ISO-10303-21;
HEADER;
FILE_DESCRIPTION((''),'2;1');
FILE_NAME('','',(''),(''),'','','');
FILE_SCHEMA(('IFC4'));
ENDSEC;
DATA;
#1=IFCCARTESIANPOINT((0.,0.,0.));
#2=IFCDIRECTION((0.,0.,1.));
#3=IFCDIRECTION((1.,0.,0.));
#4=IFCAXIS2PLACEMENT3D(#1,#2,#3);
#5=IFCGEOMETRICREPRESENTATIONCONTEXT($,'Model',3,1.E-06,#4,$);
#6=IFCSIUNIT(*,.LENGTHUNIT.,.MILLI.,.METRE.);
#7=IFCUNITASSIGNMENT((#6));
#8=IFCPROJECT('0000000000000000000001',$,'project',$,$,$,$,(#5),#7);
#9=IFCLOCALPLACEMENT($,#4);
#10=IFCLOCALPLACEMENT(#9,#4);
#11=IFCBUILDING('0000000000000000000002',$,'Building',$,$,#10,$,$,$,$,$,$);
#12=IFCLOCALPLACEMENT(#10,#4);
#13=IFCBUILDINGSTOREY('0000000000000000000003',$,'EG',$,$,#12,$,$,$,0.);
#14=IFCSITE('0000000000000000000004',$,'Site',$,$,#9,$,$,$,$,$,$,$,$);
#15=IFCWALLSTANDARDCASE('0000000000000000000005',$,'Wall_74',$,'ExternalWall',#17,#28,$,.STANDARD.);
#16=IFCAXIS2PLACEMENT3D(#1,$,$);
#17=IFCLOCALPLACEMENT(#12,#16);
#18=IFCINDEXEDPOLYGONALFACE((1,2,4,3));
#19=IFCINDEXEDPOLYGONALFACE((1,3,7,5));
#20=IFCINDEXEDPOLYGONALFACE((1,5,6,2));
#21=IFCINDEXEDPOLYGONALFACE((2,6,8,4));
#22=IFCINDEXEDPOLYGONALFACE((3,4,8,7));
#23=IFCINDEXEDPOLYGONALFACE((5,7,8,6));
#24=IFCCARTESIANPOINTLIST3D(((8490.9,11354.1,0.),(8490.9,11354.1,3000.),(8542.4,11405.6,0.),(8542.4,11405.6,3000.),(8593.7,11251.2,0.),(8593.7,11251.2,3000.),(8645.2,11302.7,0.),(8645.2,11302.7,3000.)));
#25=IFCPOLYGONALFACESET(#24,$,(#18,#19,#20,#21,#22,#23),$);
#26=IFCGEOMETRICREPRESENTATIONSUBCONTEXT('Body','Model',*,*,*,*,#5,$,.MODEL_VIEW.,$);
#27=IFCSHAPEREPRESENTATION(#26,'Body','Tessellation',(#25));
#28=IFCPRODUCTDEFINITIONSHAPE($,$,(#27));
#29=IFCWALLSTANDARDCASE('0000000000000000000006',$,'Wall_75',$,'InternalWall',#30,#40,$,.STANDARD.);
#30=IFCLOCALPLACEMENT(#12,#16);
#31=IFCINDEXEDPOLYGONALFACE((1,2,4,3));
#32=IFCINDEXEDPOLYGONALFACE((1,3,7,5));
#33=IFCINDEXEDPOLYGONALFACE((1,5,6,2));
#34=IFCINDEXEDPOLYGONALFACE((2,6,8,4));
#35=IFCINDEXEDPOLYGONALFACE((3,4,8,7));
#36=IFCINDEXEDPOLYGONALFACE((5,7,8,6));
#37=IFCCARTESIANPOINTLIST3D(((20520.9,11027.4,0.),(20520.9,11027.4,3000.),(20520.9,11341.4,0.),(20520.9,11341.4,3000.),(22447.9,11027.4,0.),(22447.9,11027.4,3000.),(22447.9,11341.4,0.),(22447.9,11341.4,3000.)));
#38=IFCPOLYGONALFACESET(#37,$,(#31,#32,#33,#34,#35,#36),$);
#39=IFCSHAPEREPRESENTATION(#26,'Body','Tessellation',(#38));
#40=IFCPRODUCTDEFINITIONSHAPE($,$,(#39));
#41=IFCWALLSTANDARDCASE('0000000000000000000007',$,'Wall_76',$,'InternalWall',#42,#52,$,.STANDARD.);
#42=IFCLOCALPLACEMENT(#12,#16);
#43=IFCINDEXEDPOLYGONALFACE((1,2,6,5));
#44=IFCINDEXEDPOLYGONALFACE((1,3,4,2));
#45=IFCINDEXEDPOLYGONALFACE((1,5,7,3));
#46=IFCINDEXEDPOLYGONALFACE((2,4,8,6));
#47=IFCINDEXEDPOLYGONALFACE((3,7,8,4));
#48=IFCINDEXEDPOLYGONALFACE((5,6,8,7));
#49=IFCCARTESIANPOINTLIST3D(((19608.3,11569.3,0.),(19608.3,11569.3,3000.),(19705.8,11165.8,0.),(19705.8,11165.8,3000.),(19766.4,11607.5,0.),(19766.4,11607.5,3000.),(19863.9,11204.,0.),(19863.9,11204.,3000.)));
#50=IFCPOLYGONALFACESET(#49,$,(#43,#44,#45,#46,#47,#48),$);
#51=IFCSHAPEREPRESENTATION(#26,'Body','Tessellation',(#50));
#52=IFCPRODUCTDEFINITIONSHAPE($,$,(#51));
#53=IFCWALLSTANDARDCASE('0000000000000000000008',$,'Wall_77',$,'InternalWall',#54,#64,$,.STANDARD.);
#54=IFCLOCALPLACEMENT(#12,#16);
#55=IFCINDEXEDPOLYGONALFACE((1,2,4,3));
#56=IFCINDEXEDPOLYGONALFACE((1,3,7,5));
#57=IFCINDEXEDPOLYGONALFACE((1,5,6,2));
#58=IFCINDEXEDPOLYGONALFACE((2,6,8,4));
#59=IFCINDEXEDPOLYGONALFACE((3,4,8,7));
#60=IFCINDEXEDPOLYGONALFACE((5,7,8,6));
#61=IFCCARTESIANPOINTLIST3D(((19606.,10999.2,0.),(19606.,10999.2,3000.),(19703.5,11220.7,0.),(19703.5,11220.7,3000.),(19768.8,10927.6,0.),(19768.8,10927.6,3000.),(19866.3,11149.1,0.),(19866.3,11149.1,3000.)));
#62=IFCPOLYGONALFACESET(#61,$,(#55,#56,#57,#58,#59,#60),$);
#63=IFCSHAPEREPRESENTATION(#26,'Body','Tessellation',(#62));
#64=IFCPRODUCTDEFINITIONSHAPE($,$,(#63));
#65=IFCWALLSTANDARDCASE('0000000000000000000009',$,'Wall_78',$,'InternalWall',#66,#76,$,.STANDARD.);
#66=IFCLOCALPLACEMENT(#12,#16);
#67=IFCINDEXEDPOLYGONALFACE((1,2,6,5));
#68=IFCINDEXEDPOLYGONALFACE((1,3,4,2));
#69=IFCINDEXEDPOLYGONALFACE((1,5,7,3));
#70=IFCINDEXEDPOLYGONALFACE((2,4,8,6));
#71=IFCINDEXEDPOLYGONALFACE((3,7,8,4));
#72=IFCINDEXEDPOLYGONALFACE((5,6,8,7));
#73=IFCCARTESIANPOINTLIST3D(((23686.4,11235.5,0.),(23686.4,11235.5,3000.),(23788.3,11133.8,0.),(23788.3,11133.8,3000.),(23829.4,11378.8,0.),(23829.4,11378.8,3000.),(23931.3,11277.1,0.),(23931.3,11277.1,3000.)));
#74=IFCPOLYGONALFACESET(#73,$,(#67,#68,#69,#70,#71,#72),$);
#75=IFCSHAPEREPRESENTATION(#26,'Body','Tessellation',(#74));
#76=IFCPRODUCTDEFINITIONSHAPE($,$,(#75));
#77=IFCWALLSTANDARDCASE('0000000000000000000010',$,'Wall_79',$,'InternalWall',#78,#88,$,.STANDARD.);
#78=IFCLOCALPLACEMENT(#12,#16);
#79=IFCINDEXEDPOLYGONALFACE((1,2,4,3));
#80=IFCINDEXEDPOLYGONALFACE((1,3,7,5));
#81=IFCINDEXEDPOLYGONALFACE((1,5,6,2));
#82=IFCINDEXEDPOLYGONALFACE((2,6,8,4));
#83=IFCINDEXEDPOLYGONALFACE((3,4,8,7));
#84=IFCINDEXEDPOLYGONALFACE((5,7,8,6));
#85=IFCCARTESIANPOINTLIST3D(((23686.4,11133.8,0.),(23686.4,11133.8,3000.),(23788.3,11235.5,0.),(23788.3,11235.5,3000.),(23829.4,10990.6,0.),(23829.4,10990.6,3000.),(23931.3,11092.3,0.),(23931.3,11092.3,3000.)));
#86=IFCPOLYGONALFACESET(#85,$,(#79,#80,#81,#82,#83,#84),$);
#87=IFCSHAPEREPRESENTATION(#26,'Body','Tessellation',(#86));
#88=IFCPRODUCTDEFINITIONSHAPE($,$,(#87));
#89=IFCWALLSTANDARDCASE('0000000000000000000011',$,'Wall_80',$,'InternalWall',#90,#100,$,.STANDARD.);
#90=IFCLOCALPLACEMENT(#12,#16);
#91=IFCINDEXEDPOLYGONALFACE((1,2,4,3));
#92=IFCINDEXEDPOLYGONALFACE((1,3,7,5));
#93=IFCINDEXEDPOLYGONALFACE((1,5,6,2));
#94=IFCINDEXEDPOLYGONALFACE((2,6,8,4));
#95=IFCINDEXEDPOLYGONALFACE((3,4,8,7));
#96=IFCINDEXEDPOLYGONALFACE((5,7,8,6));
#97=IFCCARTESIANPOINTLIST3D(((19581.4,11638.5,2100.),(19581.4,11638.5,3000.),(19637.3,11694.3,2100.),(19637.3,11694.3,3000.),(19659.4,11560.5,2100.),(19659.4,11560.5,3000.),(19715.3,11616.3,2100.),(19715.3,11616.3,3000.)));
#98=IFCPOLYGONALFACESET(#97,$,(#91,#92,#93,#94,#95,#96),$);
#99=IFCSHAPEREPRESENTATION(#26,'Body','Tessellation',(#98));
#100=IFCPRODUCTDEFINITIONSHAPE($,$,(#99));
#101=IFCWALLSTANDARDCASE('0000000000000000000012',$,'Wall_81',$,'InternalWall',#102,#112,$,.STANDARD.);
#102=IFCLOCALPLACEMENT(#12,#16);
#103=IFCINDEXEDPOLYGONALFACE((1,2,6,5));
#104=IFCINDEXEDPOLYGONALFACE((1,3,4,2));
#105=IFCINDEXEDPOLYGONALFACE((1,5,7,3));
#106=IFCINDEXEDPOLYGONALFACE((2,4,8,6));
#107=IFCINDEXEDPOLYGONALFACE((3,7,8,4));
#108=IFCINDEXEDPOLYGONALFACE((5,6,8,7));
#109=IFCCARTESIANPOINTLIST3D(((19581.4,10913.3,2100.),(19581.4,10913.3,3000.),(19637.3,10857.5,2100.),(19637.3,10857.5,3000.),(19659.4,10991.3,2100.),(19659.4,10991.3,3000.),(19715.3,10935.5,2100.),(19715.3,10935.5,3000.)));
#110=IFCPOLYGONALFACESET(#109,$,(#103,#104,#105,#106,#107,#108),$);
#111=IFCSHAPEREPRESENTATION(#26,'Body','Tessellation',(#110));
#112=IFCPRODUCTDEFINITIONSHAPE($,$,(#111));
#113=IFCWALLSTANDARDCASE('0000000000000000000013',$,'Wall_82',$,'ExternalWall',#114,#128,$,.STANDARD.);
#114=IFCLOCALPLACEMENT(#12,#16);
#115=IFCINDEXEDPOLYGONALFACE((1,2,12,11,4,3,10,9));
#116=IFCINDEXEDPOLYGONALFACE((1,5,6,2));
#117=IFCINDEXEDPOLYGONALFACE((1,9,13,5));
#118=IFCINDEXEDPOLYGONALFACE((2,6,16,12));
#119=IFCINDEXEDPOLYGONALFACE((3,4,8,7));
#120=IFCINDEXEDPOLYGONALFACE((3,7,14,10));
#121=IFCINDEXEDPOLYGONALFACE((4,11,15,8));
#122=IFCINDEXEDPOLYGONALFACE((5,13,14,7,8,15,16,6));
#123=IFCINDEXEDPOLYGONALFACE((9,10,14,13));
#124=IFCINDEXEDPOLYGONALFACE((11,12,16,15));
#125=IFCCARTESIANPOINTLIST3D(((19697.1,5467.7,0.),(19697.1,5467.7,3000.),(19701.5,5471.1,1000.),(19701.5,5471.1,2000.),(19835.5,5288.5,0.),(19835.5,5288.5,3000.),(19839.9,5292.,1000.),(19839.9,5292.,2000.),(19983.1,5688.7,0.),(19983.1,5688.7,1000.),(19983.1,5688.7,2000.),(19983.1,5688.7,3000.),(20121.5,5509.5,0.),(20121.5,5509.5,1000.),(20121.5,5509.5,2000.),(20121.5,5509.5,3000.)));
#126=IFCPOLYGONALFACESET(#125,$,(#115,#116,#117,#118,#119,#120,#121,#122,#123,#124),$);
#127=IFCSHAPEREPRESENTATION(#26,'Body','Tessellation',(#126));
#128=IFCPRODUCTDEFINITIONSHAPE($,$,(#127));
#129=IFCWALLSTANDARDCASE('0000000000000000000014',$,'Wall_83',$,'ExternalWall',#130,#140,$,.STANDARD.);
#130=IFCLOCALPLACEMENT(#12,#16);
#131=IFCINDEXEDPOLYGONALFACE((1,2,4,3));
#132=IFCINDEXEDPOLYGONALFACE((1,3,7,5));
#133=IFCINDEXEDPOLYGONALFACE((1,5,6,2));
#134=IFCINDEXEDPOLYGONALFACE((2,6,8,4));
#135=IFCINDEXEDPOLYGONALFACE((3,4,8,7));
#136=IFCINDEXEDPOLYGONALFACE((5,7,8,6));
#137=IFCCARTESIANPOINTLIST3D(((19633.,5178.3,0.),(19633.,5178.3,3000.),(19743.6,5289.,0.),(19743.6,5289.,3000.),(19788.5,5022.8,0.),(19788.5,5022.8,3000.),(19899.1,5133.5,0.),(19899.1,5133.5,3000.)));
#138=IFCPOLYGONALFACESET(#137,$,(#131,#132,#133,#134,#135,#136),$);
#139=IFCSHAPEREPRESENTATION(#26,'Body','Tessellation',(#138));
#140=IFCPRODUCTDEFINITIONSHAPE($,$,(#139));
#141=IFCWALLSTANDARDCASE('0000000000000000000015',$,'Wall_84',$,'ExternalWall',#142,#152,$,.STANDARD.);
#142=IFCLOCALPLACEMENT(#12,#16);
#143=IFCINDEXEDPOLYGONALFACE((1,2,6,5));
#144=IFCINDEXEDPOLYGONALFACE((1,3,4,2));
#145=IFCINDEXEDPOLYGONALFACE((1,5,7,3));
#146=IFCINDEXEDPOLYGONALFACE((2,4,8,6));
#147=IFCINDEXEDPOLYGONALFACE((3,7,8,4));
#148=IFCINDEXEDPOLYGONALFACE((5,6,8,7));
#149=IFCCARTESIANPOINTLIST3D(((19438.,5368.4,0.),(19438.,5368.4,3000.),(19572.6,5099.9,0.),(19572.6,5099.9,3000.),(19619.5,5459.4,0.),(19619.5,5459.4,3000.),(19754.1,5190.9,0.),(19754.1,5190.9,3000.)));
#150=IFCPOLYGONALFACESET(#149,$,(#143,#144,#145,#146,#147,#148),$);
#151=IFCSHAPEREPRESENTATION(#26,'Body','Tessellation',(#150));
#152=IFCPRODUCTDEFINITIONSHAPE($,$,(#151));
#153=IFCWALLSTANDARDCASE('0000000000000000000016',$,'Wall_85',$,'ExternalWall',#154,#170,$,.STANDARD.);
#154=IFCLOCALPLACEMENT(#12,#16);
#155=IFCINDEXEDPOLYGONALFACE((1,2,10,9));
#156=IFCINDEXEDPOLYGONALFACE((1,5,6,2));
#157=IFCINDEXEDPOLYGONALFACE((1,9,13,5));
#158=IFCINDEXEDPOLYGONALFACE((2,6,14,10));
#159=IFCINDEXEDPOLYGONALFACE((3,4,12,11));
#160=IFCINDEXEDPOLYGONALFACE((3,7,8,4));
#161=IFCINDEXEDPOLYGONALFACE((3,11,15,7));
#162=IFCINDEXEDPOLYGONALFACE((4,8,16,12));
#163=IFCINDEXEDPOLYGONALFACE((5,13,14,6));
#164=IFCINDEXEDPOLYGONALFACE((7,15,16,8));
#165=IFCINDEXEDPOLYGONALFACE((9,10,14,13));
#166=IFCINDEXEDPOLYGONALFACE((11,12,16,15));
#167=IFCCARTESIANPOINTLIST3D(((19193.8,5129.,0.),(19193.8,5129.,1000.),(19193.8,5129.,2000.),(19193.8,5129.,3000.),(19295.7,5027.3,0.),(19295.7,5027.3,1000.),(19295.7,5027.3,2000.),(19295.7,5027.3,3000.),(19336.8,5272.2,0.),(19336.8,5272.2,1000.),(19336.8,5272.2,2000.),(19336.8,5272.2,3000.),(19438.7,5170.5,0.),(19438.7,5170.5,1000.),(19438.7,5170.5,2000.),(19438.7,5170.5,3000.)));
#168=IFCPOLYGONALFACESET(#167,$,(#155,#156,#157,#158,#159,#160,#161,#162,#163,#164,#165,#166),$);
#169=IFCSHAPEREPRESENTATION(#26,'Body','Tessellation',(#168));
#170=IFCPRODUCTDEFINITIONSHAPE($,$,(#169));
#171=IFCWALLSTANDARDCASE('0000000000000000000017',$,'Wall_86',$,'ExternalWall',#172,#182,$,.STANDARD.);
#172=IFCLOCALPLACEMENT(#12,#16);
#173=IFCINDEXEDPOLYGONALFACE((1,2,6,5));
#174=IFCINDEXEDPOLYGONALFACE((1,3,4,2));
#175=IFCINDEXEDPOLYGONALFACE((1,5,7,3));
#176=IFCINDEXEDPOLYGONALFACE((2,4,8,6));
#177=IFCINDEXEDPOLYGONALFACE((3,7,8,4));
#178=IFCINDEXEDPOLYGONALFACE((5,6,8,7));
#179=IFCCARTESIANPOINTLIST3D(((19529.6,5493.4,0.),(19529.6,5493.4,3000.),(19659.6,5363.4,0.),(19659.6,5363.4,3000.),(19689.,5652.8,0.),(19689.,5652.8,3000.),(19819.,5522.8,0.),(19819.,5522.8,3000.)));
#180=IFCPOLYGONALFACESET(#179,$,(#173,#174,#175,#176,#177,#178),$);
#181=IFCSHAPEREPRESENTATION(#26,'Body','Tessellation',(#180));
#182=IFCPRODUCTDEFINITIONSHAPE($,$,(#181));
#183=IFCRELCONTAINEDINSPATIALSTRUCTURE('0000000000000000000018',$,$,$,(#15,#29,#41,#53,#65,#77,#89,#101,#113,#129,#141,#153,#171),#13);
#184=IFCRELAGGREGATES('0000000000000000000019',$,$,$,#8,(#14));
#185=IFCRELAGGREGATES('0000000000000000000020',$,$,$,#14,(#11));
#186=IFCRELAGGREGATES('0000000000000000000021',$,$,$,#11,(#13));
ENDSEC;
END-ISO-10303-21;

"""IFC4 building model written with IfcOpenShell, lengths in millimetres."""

from ifc_helpers import new_model, si_unit, frame, origin_with_axes, place, context, subcontext, project, spatial, rectangle, extrude, element, save


model = new_model("IFC4")

# Units and contexts
model_context = context("Model", 3, precision=1e-06, world=origin_with_axes())
body_context = subcontext(model_context, "Body", "Model", "MODEL_VIEW")
ifc_project = project(units=[si_unit("LENGTHUNIT", "METRE", prefix="MILLI")], contexts=[model_context])

# Site, building, storey
site_placement = place(None, origin_with_axes())
site = spatial("IfcSite", under=ifc_project, at=site_placement, Name="Site")
building_placement = place(site_placement, origin_with_axes())
building = spatial("IfcBuilding", under=site, at=building_placement, Name="Building")
storey_placement = place(building_placement, origin_with_axes())
storey = spatial("IfcBuildingStorey", under=building, at=storey_placement, Name="EG", Elevation=0.0)

# Walls
wall_1_placement = place(storey_placement, origin_with_axes())
element("IfcWallStandardCase", 1, at=wall_1_placement, inside=storey, Name="Wall_74", ObjectType="ExternalWall", PredefinedType="STANDARD", context=body_context, shape_type="SweptSolid", body=[
    extrude(rectangle(XDim=72.8, YDim=145.5), frame((8568.0, 11328.4, 0.0), z_axis=(0.0, 0.0, 1.0), x_axis=(-0.707107, -0.707107, 0.0)), (0.0, 0.0, 1.0), 3000.0),
])
wall_2_placement = place(storey_placement, origin_with_axes())
element("IfcWallStandardCase", 2, at=wall_2_placement, inside=storey, Name="Wall_75", ObjectType="InternalWall", PredefinedType="STANDARD", context=body_context, shape_type="SweptSolid", body=[
    extrude(rectangle(XDim=1927.0, YDim=314.0), frame((21484.4, 11184.4, 0.0), z_axis=(0.0, 0.0, 1.0), x_axis=(1.0, 0.0, 0.0)), (0.0, 0.0, 1.0), 3000.0),
])
wall_3_placement = place(storey_placement, origin_with_axes())
element("IfcWallStandardCase", 3, at=wall_3_placement, inside=storey, Name="Wall_76", ObjectType="InternalWall", PredefinedType="STANDARD", context=body_context, shape_type="SweptSolid", body=[
    extrude(rectangle(XDim=415.1, YDim=162.7), frame((19736.1, 11386.7, 0.0), z_axis=(0.0, 0.0, 1.0), x_axis=(0.234876, -0.972025, 0.0)), (0.0, 0.0, 1.0), 3000.0),
])
wall_4_placement = place(storey_placement, origin_with_axes())
element("IfcWallStandardCase", 4, at=wall_4_placement, inside=storey, Name="Wall_77", ObjectType="InternalWall", PredefinedType="STANDARD", context=body_context, shape_type="SweptSolid", body=[
    extrude(rectangle(XDim=242.0, YDim=177.9), frame((19736.1, 11074.2, 0.0), z_axis=(0.0, 0.0, 1.0), x_axis=(-0.402877, -0.915254, 0.0)), (0.0, 0.0, 1.0), 3000.0),
])
wall_5_placement = place(storey_placement, origin_with_axes())
element("IfcWallStandardCase", 5, at=wall_5_placement, inside=storey, Name="Wall_78", ObjectType="InternalWall", PredefinedType="STANDARD", context=body_context, shape_type="SweptSolid", body=[
    extrude(rectangle(XDim=202.4, YDim=144.0), frame((23808.9, 11256.3, 0.0), z_axis=(0.0, 0.0, 1.0), x_axis=(0.706489, 0.707724, 0.0)), (0.0, 0.0, 1.0), 3000.0),
])
wall_6_placement = place(storey_placement, origin_with_axes())
element("IfcWallStandardCase", 6, at=wall_6_placement, inside=storey, Name="Wall_79", ObjectType="InternalWall", PredefinedType="STANDARD", context=body_context, shape_type="SweptSolid", body=[
    extrude(rectangle(XDim=202.4, YDim=144.0), frame((23808.9, 11113.0, 0.0), z_axis=(0.0, 0.0, 1.0), x_axis=(0.706489, -0.707724, 0.0)), (0.0, 0.0, 1.0), 3000.0),
])

# Walls, openings
wall_7_placement = place(storey_placement, origin_with_axes())
wall_7 = element("IfcWallStandardCase", 7, at=wall_7_placement, inside=storey, Name="Wall_80", ObjectType="InternalWall", PredefinedType="STANDARD", context=body_context, shape_type="SweptSolid", body=[
    extrude(rectangle(XDim=110.3, YDim=79.0), frame((19648.4, 11627.4, 0.0), z_axis=(0.0, 0.0, 1.0), x_axis=(-0.707107, 0.707107, 0.0)), (0.0, 0.0, 1.0), 3000.0),
])
opening_1_placement = place(wall_7_placement, origin_with_axes())
element("IfcOpeningElement", 8, at=opening_1_placement, inside=storey, cuts=wall_7, context=body_context, shape_type="SweptSolid", body=[
    extrude(rectangle(XDim=450.0, YDim=79.0), frame((19648.4, 11627.4, 0.0), z_axis=(0.0, 0.0, 1.0), x_axis=(-0.707107, 0.707107, 0.0)), (0.0, 0.0, 1.0), 2100.0),
])
wall_8_placement = place(storey_placement, origin_with_axes())
wall_8 = element("IfcWallStandardCase", 9, at=wall_8_placement, inside=storey, Name="Wall_81", ObjectType="InternalWall", PredefinedType="STANDARD", context=body_context, shape_type="SweptSolid", body=[
    extrude(rectangle(XDim=110.3, YDim=79.0), frame((19648.4, 10924.4, 0.0), z_axis=(0.0, 0.0, 1.0), x_axis=(-0.707107, -0.707107, 0.0)), (0.0, 0.0, 1.0), 3000.0),
])
opening_2_placement = place(wall_8_placement, origin_with_axes())
element("IfcOpeningElement", 10, at=opening_2_placement, inside=storey, cuts=wall_8, context=body_context, shape_type="SweptSolid", body=[
    extrude(rectangle(XDim=450.0, YDim=79.0), frame((19648.4, 10924.4, 0.0), z_axis=(0.0, 0.0, 1.0), x_axis=(-0.707107, -0.707107, 0.0)), (0.0, 0.0, 1.0), 2100.0),
])
wall_9_placement = place(storey_placement, origin_with_axes())
wall_9 = element("IfcWallStandardCase", 11, at=wall_9_placement, inside=storey, Name="Wall_82", ObjectType="ExternalWall", PredefinedType="STANDARD", context=body_context, shape_type="SweptSolid", body=[
    extrude(rectangle(XDim=361.4, YDim=226.4), frame((19909.3, 5488.6, 0.0), z_axis=(0.0, 0.0, 1.0), x_axis=(-0.791285, -0.611448, 0.0)), (0.0, 0.0, 1.0), 3000.0),
])
opening_3_placement = place(wall_9_placement, origin_with_axes())
element("IfcOpeningElement", 12, at=opening_3_placement, inside=storey, cuts=wall_9, context=body_context, shape_type="SweptSolid", body=[
    extrude(rectangle(XDim=600.0, YDim=226.4), frame((20008.1, 5565.0, 1000.0), z_axis=(0.0, 0.0, 1.0), x_axis=(-0.791285, -0.611448, 0.0)), (0.0, 0.0, 1.0), 1000.0),
])

# Walls
wall_10_placement = place(storey_placement, origin_with_axes())
element("IfcWallStandardCase", 13, at=wall_10_placement, inside=storey, Name="Wall_83", ObjectType="ExternalWall", PredefinedType="STANDARD", context=body_context, shape_type="SweptSolid", body=[
    extrude(rectangle(XDim=219.9, YDim=156.5), frame((19766.0, 5155.9, 0.0), z_axis=(0.0, 0.0, 1.0), x_axis=(0.707107, -0.707107, 0.0)), (0.0, 0.0, 1.0), 3000.0),
])
wall_11_placement = place(storey_placement, origin_with_axes())
element("IfcWallStandardCase", 14, at=wall_11_placement, inside=storey, Name="Wall_84", ObjectType="ExternalWall", PredefinedType="STANDARD", context=body_context, shape_type="SweptSolid", body=[
    extrude(rectangle(XDim=203.0, YDim=300.4), frame((19596.0, 5279.6, 0.0), z_axis=(0.0, 0.0, 1.0), x_axis=(0.893934, 0.448198, 0.0)), (0.0, 0.0, 1.0), 3000.0),
])

# Wall, opening
wall_12_placement = place(storey_placement, origin_with_axes())
wall_12 = element("IfcWallStandardCase", 15, at=wall_12_placement, inside=storey, Name="Wall_85", ObjectType="ExternalWall", PredefinedType="STANDARD", context=body_context, shape_type="SweptSolid", body=[
    extrude(rectangle(XDim=202.4, YDim=144.0), frame((19316.3, 5149.8, 0.0), z_axis=(0.0, 0.0, 1.0), x_axis=(-0.706489, -0.707724, 0.0)), (0.0, 0.0, 1.0), 3000.0),
])
opening_4_placement = place(wall_12_placement, origin_with_axes())
element("IfcOpeningElement", 16, at=opening_4_placement, inside=storey, cuts=wall_12, context=body_context, shape_type="SweptSolid", body=[
    extrude(rectangle(XDim=600.0, YDim=144.0), frame((19296.9, 5130.3, 1000.0), z_axis=(0.0, 0.0, 1.0), x_axis=(-0.706489, -0.707724, 0.0)), (0.0, 0.0, 1.0), 1000.0),
])

# Wall
wall_13_placement = place(storey_placement, origin_with_axes())
element("IfcWallStandardCase", 17, at=wall_13_placement, inside=storey, Name="Wall_86", ObjectType="ExternalWall", PredefinedType="STANDARD", context=body_context, shape_type="SweptSolid", body=[
    extrude(rectangle(XDim=183.8, YDim=225.4), frame((19674.3, 5508.1, 0.0), z_axis=(0.0, 0.0, 1.0), x_axis=(0.707107, -0.707107, 0.0)), (0.0, 0.0, 1.0), 3000.0),
])

save(model, "model.ifc")
